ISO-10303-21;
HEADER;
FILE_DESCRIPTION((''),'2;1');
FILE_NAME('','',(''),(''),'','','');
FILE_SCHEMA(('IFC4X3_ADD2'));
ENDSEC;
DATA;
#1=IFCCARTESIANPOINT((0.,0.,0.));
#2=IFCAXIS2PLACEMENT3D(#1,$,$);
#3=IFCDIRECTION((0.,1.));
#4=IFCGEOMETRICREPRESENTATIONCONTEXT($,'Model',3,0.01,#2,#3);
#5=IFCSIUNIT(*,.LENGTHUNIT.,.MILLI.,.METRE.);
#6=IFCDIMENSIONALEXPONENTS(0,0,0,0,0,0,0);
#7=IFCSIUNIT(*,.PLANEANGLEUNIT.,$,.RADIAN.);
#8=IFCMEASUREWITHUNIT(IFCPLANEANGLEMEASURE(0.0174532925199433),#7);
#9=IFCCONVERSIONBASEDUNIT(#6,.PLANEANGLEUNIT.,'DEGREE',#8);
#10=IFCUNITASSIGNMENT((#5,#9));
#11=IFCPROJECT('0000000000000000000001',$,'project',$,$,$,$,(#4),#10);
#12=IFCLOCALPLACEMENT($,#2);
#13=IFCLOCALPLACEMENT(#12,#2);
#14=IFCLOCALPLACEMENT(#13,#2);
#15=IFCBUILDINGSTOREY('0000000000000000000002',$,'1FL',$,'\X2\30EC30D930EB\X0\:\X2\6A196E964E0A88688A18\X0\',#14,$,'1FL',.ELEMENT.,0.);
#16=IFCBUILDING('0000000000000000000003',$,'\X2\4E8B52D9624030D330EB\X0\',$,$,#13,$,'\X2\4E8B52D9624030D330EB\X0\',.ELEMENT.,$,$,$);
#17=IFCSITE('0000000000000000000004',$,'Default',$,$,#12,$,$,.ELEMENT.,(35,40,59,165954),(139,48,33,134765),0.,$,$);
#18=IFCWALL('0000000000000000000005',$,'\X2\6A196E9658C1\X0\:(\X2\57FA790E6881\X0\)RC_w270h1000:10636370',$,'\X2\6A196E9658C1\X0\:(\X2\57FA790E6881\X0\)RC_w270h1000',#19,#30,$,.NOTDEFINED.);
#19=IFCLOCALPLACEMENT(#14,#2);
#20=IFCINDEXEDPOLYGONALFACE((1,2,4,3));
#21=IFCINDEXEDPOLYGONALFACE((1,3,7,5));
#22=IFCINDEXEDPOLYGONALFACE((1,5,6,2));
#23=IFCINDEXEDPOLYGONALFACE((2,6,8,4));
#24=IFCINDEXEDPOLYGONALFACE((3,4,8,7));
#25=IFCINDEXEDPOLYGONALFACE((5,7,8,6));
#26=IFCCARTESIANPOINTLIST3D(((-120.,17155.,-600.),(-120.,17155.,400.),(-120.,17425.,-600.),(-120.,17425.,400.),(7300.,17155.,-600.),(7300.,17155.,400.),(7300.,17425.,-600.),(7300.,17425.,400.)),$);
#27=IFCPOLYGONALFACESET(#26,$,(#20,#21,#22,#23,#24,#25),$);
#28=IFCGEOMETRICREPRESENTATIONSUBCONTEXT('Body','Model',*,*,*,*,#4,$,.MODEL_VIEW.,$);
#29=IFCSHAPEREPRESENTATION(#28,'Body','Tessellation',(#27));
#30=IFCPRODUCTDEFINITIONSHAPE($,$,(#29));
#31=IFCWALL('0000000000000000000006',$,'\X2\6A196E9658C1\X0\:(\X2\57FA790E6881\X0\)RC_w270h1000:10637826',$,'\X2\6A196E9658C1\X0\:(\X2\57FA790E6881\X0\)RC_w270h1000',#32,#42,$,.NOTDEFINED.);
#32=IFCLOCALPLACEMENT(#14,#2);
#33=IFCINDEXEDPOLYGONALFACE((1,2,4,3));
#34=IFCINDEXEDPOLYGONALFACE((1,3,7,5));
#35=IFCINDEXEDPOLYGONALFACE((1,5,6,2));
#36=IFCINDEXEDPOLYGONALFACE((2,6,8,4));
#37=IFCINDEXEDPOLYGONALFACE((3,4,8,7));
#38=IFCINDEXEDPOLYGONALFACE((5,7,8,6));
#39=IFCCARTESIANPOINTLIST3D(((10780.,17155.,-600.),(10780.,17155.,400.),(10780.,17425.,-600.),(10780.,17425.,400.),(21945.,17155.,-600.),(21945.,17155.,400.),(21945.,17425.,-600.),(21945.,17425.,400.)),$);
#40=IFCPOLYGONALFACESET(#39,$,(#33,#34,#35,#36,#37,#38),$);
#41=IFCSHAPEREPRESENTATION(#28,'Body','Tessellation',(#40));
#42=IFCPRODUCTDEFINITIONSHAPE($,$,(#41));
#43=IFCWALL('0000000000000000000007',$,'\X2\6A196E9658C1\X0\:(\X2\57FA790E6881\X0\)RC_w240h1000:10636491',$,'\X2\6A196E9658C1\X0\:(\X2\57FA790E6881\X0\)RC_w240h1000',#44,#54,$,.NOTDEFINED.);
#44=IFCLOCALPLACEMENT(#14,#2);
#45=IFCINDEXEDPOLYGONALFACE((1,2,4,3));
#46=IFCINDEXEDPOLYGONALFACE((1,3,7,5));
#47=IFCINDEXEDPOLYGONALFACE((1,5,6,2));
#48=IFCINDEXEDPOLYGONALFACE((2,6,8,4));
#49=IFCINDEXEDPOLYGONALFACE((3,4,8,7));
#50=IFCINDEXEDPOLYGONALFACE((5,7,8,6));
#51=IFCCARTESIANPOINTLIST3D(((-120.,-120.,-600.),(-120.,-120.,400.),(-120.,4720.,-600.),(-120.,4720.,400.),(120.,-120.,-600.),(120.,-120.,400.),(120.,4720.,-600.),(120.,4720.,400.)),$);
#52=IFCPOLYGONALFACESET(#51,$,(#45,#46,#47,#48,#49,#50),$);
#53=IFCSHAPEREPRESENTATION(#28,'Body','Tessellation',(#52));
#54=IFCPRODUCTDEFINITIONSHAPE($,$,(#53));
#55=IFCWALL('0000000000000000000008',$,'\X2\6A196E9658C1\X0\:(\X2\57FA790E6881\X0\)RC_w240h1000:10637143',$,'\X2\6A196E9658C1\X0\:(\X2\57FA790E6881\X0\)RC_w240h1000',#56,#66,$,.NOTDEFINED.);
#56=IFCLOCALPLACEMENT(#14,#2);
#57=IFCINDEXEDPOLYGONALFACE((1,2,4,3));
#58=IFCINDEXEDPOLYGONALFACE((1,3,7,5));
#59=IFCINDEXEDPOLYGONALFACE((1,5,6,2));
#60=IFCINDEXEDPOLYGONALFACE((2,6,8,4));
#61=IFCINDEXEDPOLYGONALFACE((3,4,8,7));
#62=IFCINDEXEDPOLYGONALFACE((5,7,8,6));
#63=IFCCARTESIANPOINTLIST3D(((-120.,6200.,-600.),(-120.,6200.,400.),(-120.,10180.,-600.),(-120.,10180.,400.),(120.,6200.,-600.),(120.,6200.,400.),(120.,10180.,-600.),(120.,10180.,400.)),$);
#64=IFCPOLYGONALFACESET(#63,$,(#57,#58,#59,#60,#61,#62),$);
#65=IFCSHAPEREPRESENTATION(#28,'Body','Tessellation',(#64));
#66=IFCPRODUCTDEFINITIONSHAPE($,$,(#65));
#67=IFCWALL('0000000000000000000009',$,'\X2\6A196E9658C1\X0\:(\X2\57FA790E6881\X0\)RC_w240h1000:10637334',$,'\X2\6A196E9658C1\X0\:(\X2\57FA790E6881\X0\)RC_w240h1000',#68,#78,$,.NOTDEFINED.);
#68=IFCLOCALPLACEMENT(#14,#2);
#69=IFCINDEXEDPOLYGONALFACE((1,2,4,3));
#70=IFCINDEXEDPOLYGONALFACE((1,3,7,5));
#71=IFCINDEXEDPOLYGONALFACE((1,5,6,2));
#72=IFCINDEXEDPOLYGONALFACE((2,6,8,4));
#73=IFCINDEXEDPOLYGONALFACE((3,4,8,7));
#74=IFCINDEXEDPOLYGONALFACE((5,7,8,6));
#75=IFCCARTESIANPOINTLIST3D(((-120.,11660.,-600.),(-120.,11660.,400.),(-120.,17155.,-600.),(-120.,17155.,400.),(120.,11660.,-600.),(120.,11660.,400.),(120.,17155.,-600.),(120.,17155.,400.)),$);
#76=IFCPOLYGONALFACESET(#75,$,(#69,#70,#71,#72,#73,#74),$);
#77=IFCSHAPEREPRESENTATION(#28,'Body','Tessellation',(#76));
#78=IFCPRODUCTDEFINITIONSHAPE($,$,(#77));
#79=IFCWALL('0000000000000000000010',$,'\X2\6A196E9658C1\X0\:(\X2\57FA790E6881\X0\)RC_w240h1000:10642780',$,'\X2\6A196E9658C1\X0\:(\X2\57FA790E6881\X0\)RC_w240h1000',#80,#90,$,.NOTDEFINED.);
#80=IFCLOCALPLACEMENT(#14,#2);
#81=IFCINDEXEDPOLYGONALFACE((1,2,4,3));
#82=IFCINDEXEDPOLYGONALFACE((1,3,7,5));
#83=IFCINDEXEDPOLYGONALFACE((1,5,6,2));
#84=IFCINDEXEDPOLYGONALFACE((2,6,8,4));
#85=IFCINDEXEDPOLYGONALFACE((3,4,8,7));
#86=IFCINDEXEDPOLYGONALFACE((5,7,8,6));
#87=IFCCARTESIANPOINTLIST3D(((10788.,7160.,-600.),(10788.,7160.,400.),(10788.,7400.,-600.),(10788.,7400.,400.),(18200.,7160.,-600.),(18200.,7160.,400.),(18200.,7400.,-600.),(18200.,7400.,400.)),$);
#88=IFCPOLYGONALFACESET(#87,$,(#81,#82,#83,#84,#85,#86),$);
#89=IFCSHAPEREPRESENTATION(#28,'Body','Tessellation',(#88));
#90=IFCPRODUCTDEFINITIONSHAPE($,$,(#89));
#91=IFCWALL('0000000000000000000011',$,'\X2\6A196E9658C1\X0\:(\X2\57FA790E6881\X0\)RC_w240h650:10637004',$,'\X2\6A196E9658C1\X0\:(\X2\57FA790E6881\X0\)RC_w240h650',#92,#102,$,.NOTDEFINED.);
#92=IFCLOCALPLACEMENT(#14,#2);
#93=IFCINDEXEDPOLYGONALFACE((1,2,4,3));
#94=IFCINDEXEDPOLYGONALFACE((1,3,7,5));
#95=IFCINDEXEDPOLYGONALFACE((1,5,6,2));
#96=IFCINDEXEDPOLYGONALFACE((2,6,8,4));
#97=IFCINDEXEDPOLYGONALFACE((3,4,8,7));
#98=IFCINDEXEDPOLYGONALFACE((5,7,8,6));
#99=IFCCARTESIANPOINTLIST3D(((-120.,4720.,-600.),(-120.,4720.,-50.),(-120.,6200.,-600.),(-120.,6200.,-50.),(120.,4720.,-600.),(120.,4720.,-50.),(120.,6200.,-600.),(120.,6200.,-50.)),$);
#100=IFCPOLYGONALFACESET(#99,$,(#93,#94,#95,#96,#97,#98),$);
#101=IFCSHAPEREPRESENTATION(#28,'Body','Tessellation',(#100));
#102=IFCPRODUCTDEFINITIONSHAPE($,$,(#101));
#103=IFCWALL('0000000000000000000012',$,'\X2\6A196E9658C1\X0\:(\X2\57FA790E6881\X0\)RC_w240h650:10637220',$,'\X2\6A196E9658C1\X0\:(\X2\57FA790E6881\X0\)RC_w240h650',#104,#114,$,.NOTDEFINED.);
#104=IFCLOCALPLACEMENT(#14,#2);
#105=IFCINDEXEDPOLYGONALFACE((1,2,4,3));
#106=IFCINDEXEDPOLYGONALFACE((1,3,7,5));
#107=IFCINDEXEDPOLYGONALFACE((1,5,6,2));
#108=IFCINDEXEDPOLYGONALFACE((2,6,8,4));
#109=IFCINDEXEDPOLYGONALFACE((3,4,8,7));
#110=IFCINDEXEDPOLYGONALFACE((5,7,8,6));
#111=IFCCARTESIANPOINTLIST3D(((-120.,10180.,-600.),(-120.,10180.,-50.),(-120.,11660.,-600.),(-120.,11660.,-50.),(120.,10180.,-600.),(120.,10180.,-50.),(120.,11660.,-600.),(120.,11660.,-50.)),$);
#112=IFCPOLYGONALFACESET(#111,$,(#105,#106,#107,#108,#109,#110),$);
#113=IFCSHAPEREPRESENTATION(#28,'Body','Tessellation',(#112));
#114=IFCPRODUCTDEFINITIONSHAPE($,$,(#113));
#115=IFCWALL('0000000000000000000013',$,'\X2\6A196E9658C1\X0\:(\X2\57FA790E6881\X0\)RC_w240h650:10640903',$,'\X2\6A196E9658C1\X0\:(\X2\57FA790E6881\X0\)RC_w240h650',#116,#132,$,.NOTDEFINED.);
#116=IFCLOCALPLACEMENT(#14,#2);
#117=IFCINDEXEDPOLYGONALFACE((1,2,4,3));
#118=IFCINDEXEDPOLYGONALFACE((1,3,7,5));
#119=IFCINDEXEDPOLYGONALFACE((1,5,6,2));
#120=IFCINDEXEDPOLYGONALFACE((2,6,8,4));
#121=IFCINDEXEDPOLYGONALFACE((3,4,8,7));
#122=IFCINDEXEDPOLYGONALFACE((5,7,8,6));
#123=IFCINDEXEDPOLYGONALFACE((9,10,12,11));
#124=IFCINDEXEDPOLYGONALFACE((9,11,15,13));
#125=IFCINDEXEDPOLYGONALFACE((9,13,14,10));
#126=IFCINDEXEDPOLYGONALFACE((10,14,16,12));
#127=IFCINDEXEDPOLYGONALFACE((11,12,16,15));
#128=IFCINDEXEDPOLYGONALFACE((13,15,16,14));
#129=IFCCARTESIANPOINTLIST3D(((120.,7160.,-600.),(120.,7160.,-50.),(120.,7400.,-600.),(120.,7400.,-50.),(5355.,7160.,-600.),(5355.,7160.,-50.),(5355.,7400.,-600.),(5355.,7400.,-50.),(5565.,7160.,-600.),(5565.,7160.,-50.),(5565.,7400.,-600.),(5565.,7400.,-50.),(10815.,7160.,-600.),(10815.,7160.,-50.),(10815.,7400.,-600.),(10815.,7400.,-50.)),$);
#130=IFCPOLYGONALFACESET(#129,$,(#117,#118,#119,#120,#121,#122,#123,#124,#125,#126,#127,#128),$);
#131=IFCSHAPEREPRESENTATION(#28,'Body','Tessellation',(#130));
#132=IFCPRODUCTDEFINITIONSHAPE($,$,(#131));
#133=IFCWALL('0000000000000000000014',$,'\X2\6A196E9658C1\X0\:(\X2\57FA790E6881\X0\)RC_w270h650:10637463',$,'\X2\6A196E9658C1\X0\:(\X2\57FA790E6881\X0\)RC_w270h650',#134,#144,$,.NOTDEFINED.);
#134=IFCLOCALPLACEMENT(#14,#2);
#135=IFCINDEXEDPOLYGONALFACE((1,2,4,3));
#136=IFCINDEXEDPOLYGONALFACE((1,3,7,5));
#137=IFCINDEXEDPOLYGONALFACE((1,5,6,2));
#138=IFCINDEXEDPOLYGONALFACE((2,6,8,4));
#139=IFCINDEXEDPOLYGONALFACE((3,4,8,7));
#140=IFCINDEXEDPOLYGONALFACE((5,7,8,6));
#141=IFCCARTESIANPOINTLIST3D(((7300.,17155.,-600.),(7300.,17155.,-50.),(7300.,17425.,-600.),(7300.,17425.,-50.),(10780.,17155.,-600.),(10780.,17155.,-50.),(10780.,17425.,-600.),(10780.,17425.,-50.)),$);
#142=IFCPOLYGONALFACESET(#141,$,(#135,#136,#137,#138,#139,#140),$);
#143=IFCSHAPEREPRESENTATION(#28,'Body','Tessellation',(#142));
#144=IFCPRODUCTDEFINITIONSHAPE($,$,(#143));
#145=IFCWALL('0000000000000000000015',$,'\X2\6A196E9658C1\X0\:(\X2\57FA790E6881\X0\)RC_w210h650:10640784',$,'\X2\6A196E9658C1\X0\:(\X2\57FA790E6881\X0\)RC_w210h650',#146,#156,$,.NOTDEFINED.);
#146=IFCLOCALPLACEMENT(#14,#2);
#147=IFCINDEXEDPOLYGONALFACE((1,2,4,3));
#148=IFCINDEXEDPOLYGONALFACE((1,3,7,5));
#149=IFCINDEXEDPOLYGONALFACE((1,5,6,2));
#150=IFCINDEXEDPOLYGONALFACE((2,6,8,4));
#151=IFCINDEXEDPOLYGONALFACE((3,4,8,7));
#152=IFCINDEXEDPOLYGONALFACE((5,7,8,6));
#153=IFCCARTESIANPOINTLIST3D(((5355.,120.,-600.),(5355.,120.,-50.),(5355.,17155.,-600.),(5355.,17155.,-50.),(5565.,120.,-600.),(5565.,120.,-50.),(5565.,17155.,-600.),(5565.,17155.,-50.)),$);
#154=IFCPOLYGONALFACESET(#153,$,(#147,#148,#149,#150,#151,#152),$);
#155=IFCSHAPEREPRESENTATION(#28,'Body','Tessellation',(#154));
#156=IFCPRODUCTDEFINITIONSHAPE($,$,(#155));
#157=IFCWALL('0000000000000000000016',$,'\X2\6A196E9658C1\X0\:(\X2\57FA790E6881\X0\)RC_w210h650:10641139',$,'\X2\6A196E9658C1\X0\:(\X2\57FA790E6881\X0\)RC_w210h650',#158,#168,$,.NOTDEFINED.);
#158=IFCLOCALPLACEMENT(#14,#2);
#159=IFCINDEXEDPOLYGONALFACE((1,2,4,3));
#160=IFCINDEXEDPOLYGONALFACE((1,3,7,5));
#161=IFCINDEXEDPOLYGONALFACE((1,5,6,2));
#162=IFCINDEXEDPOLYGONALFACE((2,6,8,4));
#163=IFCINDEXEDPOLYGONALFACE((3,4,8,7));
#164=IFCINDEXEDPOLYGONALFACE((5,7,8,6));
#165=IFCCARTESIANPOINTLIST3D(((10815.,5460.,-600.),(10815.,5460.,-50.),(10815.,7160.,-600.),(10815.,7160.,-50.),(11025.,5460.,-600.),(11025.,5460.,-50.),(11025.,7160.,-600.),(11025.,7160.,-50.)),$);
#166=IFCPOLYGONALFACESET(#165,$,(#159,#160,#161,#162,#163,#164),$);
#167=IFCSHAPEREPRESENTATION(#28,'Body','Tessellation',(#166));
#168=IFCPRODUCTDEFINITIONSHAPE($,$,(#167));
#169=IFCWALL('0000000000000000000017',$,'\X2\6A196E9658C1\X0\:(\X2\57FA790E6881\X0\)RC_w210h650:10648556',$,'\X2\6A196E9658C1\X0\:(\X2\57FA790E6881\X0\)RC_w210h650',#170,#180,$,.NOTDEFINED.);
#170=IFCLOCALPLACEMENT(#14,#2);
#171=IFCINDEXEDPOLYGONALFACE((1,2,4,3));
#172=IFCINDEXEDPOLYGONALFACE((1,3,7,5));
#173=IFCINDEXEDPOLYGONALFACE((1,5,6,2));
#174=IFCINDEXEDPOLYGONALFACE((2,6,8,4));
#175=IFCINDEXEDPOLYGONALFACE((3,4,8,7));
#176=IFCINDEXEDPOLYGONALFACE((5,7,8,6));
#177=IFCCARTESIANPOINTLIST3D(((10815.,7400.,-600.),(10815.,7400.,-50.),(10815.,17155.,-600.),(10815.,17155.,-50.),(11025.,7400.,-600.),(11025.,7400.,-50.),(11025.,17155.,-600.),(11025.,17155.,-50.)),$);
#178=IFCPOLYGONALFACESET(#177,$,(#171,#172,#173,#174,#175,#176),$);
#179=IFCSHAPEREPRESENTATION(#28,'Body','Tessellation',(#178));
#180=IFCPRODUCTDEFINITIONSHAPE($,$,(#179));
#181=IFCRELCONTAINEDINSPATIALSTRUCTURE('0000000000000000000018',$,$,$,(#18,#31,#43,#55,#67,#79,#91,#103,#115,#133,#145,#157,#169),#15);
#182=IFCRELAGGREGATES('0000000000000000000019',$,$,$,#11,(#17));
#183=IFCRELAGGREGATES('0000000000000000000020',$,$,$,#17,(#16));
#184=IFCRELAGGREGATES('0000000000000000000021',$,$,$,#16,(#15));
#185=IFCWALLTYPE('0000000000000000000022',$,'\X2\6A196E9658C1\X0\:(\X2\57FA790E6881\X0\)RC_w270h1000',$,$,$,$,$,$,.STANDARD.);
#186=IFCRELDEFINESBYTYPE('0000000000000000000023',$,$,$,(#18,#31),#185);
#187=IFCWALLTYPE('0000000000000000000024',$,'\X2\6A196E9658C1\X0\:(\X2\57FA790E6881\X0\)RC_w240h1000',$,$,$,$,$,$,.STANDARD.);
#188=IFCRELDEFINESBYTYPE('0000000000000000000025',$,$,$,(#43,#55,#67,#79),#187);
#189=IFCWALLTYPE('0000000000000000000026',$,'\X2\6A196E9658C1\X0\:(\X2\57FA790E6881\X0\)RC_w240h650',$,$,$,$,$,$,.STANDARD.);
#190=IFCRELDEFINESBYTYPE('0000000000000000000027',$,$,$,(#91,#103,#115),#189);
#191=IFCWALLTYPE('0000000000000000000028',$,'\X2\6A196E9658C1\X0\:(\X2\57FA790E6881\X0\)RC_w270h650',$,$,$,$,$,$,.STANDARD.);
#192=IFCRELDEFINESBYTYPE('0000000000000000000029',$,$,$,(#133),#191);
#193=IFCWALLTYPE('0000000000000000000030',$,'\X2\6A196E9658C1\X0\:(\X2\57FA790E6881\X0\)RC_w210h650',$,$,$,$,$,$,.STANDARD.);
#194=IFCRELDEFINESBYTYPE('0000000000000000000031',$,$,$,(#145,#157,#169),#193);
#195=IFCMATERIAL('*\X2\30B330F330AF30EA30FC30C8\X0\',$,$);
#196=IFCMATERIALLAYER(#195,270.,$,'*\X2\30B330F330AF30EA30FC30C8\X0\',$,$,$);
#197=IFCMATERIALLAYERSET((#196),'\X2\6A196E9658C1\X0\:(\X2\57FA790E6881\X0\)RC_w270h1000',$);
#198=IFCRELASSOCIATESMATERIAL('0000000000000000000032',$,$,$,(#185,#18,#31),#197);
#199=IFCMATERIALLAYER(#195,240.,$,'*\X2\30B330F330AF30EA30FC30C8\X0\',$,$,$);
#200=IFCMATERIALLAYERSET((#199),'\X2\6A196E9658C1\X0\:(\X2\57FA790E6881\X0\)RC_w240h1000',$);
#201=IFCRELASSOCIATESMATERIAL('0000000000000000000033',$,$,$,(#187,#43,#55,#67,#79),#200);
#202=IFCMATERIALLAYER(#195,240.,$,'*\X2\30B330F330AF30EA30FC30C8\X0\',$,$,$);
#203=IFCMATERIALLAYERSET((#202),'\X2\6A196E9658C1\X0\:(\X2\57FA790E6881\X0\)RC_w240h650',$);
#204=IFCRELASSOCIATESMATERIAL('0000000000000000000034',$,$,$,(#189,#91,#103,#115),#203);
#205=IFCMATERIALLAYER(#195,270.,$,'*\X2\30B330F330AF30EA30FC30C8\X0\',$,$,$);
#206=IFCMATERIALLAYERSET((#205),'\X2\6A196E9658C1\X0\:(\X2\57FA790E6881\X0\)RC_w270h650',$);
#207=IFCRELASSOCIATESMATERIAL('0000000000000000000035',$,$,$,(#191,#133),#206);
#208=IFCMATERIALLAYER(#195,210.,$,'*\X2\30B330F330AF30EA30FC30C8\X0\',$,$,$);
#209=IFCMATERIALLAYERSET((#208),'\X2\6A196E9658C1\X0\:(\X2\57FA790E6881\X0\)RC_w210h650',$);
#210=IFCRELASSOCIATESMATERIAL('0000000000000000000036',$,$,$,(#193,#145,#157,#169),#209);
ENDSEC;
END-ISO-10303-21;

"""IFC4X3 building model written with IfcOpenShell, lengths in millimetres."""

from ifc_helpers import new_model, entity, si_unit, converted_unit, direction, frame, frame_2d, origin, origin_2d_with_axis, place, context, subcontext, project, spatial, rectangle, extrude, material, layer, layer_set, type_object, element, save


model = new_model("IFC4X3")

# Units and contexts
model_context = context("Model", 3, precision=0.01, world=origin(), true_north=direction((0.0, 1.0)))
body_context = subcontext(model_context, "Body", "Model", "MODEL_VIEW")
ifc_project = project(units=[si_unit("LENGTHUNIT", "METRE", prefix="MILLI"), converted_unit("PLANEANGLEUNIT", "DEGREE", entity("IfcPlaneAngleMeasure", 0.0174532925199433), si_unit("PLANEANGLEUNIT", "RADIAN"), dimensions=[0, 0, 0, 0, 0, 0, 0])], contexts=[model_context])

# Site, building, storey
site_placement = place(None, origin())
site = spatial("IfcSite", under=ifc_project, at=site_placement, Name="Default", CompositionType="ELEMENT", RefLatitude=(35, 40, 59, 165954), RefLongitude=(139, 48, 33, 134765), RefElevation=0.0)
building_placement = place(site_placement, origin())
building = spatial("IfcBuilding", under=site, at=building_placement, Name="事務所ビル", LongName="事務所ビル", CompositionType="ELEMENT")
storey_placement = place(building_placement, origin())
storey = spatial("IfcBuildingStorey", under=building, at=storey_placement, Name="1FL", ObjectType="レベル:標準上表記", LongName="1FL", CompositionType="ELEMENT", Elevation=0.0)

# Walls
ifc_material_1 = material(Name="*コンクリート")
ifc_layer_1 = layer(ifc_material_1, 270.0, Name="*コンクリート")
ifc_layer_set_1 = layer_set([ifc_layer_1], Name="標準壁:(基礎梁)RC_w270h1000")
wall_type_1 = type_object("IfcWallType", Name="標準壁:(基礎梁)RC_w270h1000", PredefinedType="STANDARD", material=ifc_layer_set_1)
wall_1_placement = place(storey_placement, frame((-120.0, 17290.0, -600.0)))
element("IfcWall", 1, at=wall_1_placement, inside=storey, type_object=wall_type_1, material=ifc_layer_set_1, Name="標準壁:(基礎梁)RC_w270h1000:10636370", ObjectType="標準壁:(基礎梁)RC_w270h1000", PredefinedType="NOTDEFINED", context=body_context, shape_type="SweptSolid", body=[
    extrude(rectangle(XDim=7420.0, YDim=270.0, at=frame_2d((3710.0, 0.0), x_axis=(-1.0, 0.0))), origin(), (0.0, 0.0, 1.0), 1000.0),
])
wall_2_placement = place(storey_placement, frame((10780.0, 17290.0, -600.0)))
element("IfcWall", 2, at=wall_2_placement, inside=storey, type_object=wall_type_1, material=ifc_layer_set_1, Name="標準壁:(基礎梁)RC_w270h1000:10637826", ObjectType="標準壁:(基礎梁)RC_w270h1000", PredefinedType="NOTDEFINED", context=body_context, shape_type="SweptSolid", body=[
    extrude(rectangle(XDim=11165.0, YDim=270.0, at=frame_2d((5582.5, 0.0), x_axis=(-1.0, 0.0))), origin(), (0.0, 0.0, 1.0), 1000.0),
])
ifc_layer_2 = layer(ifc_material_1, 240.0, Name="*コンクリート")
ifc_layer_set_2 = layer_set([ifc_layer_2], Name="標準壁:(基礎梁)RC_w240h1000")
wall_type_2 = type_object("IfcWallType", Name="標準壁:(基礎梁)RC_w240h1000", PredefinedType="STANDARD", material=ifc_layer_set_2)
wall_3_placement = place(storey_placement, frame((0.0, -120.0, -600.0), z_axis=(0.0, 0.0, 1.0), x_axis=(0.0, 1.0, 0.0)))
element("IfcWall", 3, at=wall_3_placement, inside=storey, type_object=wall_type_2, material=ifc_layer_set_2, Name="標準壁:(基礎梁)RC_w240h1000:10636491", ObjectType="標準壁:(基礎梁)RC_w240h1000", PredefinedType="NOTDEFINED", context=body_context, shape_type="SweptSolid", body=[
    extrude(rectangle(XDim=4840.0, YDim=240.0, at=frame_2d((2420.0, 0.0), x_axis=(-1.0, 0.0))), origin(), (0.0, 0.0, 1.0), 1000.0),
])
wall_4_placement = place(storey_placement, frame((0.0, 6200.0, -600.0), z_axis=(0.0, 0.0, 1.0), x_axis=(0.0, 1.0, 0.0)))
element("IfcWall", 4, at=wall_4_placement, inside=storey, type_object=wall_type_2, material=ifc_layer_set_2, Name="標準壁:(基礎梁)RC_w240h1000:10637143", ObjectType="標準壁:(基礎梁)RC_w240h1000", PredefinedType="NOTDEFINED", context=body_context, shape_type="SweptSolid", body=[
    extrude(rectangle(XDim=3980.0, YDim=240.0, at=frame_2d((1990.0, 0.0), x_axis=(-1.0, 0.0))), origin(), (0.0, 0.0, 1.0), 1000.0),
])
wall_5_placement = place(storey_placement, frame((0.0, 11660.0, -600.0), z_axis=(0.0, 0.0, 1.0), x_axis=(0.0, 1.0, 0.0)))
element("IfcWall", 5, at=wall_5_placement, inside=storey, type_object=wall_type_2, material=ifc_layer_set_2, Name="標準壁:(基礎梁)RC_w240h1000:10637334", ObjectType="標準壁:(基礎梁)RC_w240h1000", PredefinedType="NOTDEFINED", context=body_context, shape_type="SweptSolid", body=[
    extrude(rectangle(XDim=5495.0, YDim=240.0, at=frame_2d((2747.5, 0.0), x_axis=(-1.0, 0.0))), origin(), (0.0, 0.0, 1.0), 1000.0),
])

# Walls
wall_6_placement = place(storey_placement, frame((10788.0, 7280.0, -600.0)))
element("IfcWall", 6, at=wall_6_placement, inside=storey, type_object=wall_type_2, material=ifc_layer_set_2, Name="標準壁:(基礎梁)RC_w240h1000:10642780", ObjectType="標準壁:(基礎梁)RC_w240h1000", PredefinedType="NOTDEFINED", context=body_context, shape_type="SweptSolid", body=[
    extrude(rectangle(XDim=7412.0, YDim=240.0, at=frame_2d((3706.0, 0.0), x_axis=(-1.0, 0.0))), origin(), (0.0, 0.0, 1.0), 1000.0),
])
ifc_layer_3 = layer(ifc_material_1, 240.0, Name="*コンクリート")
ifc_layer_set_3 = layer_set([ifc_layer_3], Name="標準壁:(基礎梁)RC_w240h650")
wall_type_3 = type_object("IfcWallType", Name="標準壁:(基礎梁)RC_w240h650", PredefinedType="STANDARD", material=ifc_layer_set_3)
wall_7_placement = place(storey_placement, frame((0.0, 4720.0, -600.0), z_axis=(0.0, 0.0, 1.0), x_axis=(0.0, 1.0, 0.0)))
element("IfcWall", 7, at=wall_7_placement, inside=storey, type_object=wall_type_3, material=ifc_layer_set_3, Name="標準壁:(基礎梁)RC_w240h650:10637004", ObjectType="標準壁:(基礎梁)RC_w240h650", PredefinedType="NOTDEFINED", context=body_context, shape_type="SweptSolid", body=[
    extrude(rectangle(XDim=1480.0, YDim=240.0, at=frame_2d((740.0, 0.0), x_axis=(-1.0, 0.0))), origin(), (0.0, 0.0, 1.0), 550.0),
])
wall_8_placement = place(storey_placement, frame((0.0, 10180.0, -600.0), z_axis=(0.0, 0.0, 1.0), x_axis=(0.0, 1.0, 0.0)))
element("IfcWall", 8, at=wall_8_placement, inside=storey, type_object=wall_type_3, material=ifc_layer_set_3, Name="標準壁:(基礎梁)RC_w240h650:10637220", ObjectType="標準壁:(基礎梁)RC_w240h650", PredefinedType="NOTDEFINED", context=body_context, shape_type="SweptSolid", body=[
    extrude(rectangle(XDim=1480.0, YDim=240.0, at=frame_2d((740.0, 0.0), x_axis=(-1.0, 0.0))), origin(), (0.0, 0.0, 1.0), 550.0),
])

# Wall, opening
wall_9_placement = place(storey_placement, frame((120.0, 7280.0, -600.0)))
wall_9 = element("IfcWall", 9, at=wall_9_placement, inside=storey, type_object=wall_type_3, material=ifc_layer_set_3, Name="標準壁:(基礎梁)RC_w240h650:10640903", ObjectType="標準壁:(基礎梁)RC_w240h650", PredefinedType="NOTDEFINED", context=body_context, shape_type="SweptSolid", body=[
    extrude(rectangle(XDim=10695.0, YDim=240.0, at=frame_2d((5347.5, 0.0), x_axis=(-1.0, 0.0))), origin(), (0.0, 0.0, 1.0), 550.0),
])
opening_1_placement = place(storey_placement, frame((120.0, 7280.0, -600.0)))
element("IfcOpeningElement", 10, at=opening_1_placement, cuts=wall_9, PredefinedType="OPENING", context=body_context, shape_type="SweptSolid", body=[
    extrude(rectangle(XDim=550.0, YDim=240.0, at=origin_2d_with_axis()), frame((5235.0, 0.0, 275.0), z_axis=(1.0, 0.0, 0.0), x_axis=(0.0, 0.0, -1.0)), (0.0, 0.0, 1.0), 210.0),
])

# Walls
ifc_layer_4 = layer(ifc_material_1, 270.0, Name="*コンクリート")
ifc_layer_set_4 = layer_set([ifc_layer_4], Name="標準壁:(基礎梁)RC_w270h650")
wall_type_4 = type_object("IfcWallType", Name="標準壁:(基礎梁)RC_w270h650", PredefinedType="STANDARD", material=ifc_layer_set_4)
wall_10_placement = place(storey_placement, frame((7300.0, 17290.0, -600.0)))
element("IfcWall", 11, at=wall_10_placement, inside=storey, type_object=wall_type_4, material=ifc_layer_set_4, Name="標準壁:(基礎梁)RC_w270h650:10637463", ObjectType="標準壁:(基礎梁)RC_w270h650", PredefinedType="NOTDEFINED", context=body_context, shape_type="SweptSolid", body=[
    extrude(rectangle(XDim=3480.0, YDim=270.0, at=frame_2d((1740.0, 0.0), x_axis=(-1.0, 0.0))), origin(), (0.0, 0.0, 1.0), 550.0),
])
ifc_layer_5 = layer(ifc_material_1, 210.0, Name="*コンクリート")
ifc_layer_set_5 = layer_set([ifc_layer_5], Name="標準壁:(基礎梁)RC_w210h650")
wall_type_5 = type_object("IfcWallType", Name="標準壁:(基礎梁)RC_w210h650", PredefinedType="STANDARD", material=ifc_layer_set_5)
wall_11_placement = place(storey_placement, frame((5460.0, 120.0, -600.0), z_axis=(0.0, 0.0, 1.0), x_axis=(0.0, 1.0, 0.0)))
element("IfcWall", 12, at=wall_11_placement, inside=storey, type_object=wall_type_5, material=ifc_layer_set_5, Name="標準壁:(基礎梁)RC_w210h650:10640784", ObjectType="標準壁:(基礎梁)RC_w210h650", PredefinedType="NOTDEFINED", context=body_context, shape_type="SweptSolid", body=[
    extrude(rectangle(XDim=17035.0, YDim=210.0, at=frame_2d((8517.5, 0.0), x_axis=(-1.0, 0.0))), origin(), (0.0, 0.0, 1.0), 550.0),
])
wall_12_placement = place(storey_placement, frame((10920.0, 5460.0, -600.0), z_axis=(0.0, 0.0, 1.0), x_axis=(0.0, 1.0, 0.0)))
element("IfcWall", 13, at=wall_12_placement, inside=storey, type_object=wall_type_5, material=ifc_layer_set_5, Name="標準壁:(基礎梁)RC_w210h650:10641139", ObjectType="標準壁:(基礎梁)RC_w210h650", PredefinedType="NOTDEFINED", context=body_context, shape_type="SweptSolid", body=[
    extrude(rectangle(XDim=1700.0, YDim=210.0, at=frame_2d((850.0, 0.0), x_axis=(-1.0, 0.0))), origin(), (0.0, 0.0, 1.0), 550.0),
])
wall_13_placement = place(storey_placement, frame((10920.0, 7400.0, -600.0), z_axis=(0.0, 0.0, 1.0), x_axis=(0.0, 1.0, 0.0)))
element("IfcWall", 14, at=wall_13_placement, inside=storey, type_object=wall_type_5, material=ifc_layer_set_5, Name="標準壁:(基礎梁)RC_w210h650:10648556", ObjectType="標準壁:(基礎梁)RC_w210h650", PredefinedType="NOTDEFINED", context=body_context, shape_type="SweptSolid", body=[
    extrude(rectangle(XDim=9755.0, YDim=210.0, at=frame_2d((4877.5, 0.0), x_axis=(-1.0, 0.0))), origin(), (0.0, 0.0, 1.0), 550.0),
])

save(model, "model.ifc")
